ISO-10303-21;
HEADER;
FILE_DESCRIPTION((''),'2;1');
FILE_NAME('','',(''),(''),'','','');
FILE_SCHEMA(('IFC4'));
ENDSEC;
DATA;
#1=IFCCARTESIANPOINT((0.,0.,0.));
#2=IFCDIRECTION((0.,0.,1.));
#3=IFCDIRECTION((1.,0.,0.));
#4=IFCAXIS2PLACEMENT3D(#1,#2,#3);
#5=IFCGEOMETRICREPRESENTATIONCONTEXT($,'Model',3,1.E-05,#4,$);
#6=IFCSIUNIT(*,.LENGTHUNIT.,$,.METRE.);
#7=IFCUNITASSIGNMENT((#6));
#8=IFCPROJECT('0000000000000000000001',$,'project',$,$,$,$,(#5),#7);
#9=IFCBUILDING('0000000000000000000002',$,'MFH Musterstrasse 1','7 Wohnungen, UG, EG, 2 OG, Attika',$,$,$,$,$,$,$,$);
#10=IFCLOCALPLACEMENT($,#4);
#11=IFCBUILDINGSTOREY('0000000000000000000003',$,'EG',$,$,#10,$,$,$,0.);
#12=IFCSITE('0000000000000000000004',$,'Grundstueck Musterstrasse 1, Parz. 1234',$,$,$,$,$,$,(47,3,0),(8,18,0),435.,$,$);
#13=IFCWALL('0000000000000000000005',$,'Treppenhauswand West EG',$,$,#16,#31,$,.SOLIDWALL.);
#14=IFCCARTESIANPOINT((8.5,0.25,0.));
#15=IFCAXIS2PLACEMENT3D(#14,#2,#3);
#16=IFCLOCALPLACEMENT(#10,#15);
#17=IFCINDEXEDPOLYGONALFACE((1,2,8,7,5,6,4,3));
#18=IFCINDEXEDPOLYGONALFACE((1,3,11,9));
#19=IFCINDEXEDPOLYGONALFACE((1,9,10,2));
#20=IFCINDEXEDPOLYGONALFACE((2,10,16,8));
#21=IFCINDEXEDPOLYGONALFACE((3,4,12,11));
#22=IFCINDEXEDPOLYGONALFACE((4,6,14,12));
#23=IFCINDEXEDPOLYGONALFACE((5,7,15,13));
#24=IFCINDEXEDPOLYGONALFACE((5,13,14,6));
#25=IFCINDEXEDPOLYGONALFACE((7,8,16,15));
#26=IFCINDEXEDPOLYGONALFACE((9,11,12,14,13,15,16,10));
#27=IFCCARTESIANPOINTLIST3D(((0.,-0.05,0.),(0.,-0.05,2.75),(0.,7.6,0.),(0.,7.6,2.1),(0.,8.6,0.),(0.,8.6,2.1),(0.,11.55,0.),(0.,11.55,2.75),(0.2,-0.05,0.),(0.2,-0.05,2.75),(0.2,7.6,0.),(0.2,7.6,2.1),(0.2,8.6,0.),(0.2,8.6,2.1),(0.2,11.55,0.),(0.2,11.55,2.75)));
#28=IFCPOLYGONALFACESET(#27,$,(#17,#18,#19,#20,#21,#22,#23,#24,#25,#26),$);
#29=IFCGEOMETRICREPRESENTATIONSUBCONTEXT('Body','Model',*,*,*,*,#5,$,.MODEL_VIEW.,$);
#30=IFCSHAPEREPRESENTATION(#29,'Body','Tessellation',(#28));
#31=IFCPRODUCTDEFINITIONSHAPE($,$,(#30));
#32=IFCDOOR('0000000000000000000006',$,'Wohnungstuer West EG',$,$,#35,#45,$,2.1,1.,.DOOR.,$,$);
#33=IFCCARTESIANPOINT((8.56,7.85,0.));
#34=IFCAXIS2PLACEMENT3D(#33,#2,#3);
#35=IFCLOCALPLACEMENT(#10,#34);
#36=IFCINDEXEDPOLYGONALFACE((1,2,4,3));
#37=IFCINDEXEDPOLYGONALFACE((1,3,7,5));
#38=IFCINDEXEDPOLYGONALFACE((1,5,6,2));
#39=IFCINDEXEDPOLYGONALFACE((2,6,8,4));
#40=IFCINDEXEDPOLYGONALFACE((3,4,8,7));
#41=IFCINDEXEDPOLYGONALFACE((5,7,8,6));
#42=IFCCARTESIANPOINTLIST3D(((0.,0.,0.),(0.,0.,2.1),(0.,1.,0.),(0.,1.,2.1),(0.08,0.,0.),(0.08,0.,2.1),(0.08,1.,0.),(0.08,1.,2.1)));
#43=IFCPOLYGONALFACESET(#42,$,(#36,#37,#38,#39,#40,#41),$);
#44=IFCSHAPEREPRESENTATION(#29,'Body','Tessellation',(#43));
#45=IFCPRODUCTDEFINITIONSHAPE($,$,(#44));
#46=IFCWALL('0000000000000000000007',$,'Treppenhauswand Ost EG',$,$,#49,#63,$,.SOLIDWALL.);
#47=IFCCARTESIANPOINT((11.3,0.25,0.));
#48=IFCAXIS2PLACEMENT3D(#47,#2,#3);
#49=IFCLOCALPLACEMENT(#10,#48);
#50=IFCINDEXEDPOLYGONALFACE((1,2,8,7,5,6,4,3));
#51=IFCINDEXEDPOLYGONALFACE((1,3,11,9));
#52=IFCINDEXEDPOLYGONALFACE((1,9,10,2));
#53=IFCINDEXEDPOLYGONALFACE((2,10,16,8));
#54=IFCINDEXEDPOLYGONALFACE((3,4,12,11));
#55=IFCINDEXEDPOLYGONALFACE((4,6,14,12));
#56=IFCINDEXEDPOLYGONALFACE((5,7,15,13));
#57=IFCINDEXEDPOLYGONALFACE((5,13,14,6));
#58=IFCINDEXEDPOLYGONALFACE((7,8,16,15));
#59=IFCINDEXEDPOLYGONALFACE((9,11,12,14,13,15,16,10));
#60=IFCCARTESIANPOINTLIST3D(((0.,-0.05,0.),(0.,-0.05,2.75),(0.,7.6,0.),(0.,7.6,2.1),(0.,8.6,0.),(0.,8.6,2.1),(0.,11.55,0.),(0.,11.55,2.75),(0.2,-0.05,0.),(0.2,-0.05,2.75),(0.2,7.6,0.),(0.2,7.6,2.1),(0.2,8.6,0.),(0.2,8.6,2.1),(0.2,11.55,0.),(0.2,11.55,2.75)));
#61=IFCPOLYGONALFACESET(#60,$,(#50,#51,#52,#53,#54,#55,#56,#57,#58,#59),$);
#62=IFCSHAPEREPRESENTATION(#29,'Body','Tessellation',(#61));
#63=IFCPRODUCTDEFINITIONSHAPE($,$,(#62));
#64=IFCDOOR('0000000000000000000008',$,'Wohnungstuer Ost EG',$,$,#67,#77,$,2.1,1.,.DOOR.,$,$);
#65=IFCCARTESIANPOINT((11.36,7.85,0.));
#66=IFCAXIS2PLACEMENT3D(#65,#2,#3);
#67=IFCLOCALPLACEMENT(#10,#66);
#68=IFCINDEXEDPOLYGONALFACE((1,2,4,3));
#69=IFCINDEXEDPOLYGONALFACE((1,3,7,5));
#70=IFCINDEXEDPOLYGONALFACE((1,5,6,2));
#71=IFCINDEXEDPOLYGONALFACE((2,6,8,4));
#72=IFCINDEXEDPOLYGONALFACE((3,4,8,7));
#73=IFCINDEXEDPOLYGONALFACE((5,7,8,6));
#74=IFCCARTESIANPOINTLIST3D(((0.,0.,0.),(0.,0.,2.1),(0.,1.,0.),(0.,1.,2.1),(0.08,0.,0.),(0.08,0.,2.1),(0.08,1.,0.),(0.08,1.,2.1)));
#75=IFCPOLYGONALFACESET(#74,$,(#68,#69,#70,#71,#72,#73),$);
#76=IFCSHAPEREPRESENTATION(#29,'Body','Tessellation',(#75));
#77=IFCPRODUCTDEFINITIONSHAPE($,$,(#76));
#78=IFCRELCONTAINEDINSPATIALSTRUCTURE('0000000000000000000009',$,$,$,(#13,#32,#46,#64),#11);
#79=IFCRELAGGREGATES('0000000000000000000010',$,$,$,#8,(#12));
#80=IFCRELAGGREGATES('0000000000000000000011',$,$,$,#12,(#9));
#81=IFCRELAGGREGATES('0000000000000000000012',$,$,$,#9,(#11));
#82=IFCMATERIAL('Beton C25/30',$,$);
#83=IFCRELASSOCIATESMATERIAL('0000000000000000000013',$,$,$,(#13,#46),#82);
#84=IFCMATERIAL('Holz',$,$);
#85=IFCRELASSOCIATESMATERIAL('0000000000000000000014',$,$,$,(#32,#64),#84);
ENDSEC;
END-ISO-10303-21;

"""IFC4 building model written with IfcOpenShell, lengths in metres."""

from ifc_helpers import new_model, si_unit, frame, frame_2d, origin_with_axes, place, context, subcontext, project, spatial, rectangle, extrude, material, element, fill, save


model = new_model("IFC4")

# Units and contexts
model_context = context("Model", 3, precision=1e-05, world=origin_with_axes())
body_context = subcontext(model_context, "Body", "Model", "MODEL_VIEW")
ifc_project = project(units=[si_unit("LENGTHUNIT", "METRE")], contexts=[model_context])

# Site, building, storey
site = spatial("IfcSite", under=ifc_project, Name="Grundstueck Musterstrasse 1, Parz. 1234", RefLatitude=(47, 3, 0), RefLongitude=(8, 18, 0), RefElevation=435.0)
building = spatial("IfcBuilding", under=site, Name="MFH Musterstrasse 1", Description="7 Wohnungen, UG, EG, 2 OG, Attika")
storey_placement = place(None, origin_with_axes())
storey = spatial("IfcBuildingStorey", under=building, at=storey_placement, Name="EG", Elevation=0.0)

# Walls, openings, doors
ifc_material_1 = material(Name="Beton C25/30")
wall_1_placement = place(storey_placement, frame((8.5, 0.25, 0.0), z_axis=(0.0, 0.0, 1.0), x_axis=(1.0, 0.0, 0.0)))
wall_1 = element("IfcWall", 1, at=wall_1_placement, inside=storey, material=ifc_material_1, Name="Treppenhauswand West EG", PredefinedType="SOLIDWALL", context=body_context, shape_type="SweptSolid", body=[
    extrude(rectangle(XDim=0.2, YDim=11.6, at=frame_2d((0.1, 5.75))), origin_with_axes(), (0.0, 0.0, 1.0), 2.75),
])
opening_1_placement = place(wall_1_placement, frame((-0.01, 7.6, 0.0), z_axis=(0.0, 0.0, 1.0), x_axis=(1.0, 0.0, 0.0)))
opening_1 = element("IfcOpeningElement", 2, at=opening_1_placement, cuts=wall_1, context=body_context, shape_type="SweptSolid", body=[
    extrude(rectangle(XDim=0.22, YDim=1.0, at=frame_2d((0.11, 0.5))), origin_with_axes(), (0.0, 0.0, 1.0), 2.1),
])
ifc_material_2 = material(Name="Holz")
door_1_placement = place(storey_placement, frame((8.56, 7.85, 0.0), z_axis=(0.0, 0.0, 1.0), x_axis=(1.0, 0.0, 0.0)))
door_1 = element("IfcDoor", 3, at=door_1_placement, inside=storey, material=ifc_material_2, Name="Wohnungstuer West EG", OverallHeight=2.1, OverallWidth=1.0, PredefinedType="DOOR", context=body_context, shape_type="SweptSolid", body=[
    extrude(rectangle(XDim=0.08, YDim=1.0, at=frame_2d((0.04, 0.5))), origin_with_axes(), (0.0, 0.0, 1.0), 2.1),
])
fill(opening_1, door_1)
wall_2_placement = place(storey_placement, frame((11.3, 0.25, 0.0), z_axis=(0.0, 0.0, 1.0), x_axis=(1.0, 0.0, 0.0)))
wall_2 = element("IfcWall", 4, at=wall_2_placement, inside=storey, material=ifc_material_1, Name="Treppenhauswand Ost EG", PredefinedType="SOLIDWALL", context=body_context, shape_type="SweptSolid", body=[
    extrude(rectangle(XDim=0.2, YDim=11.6, at=frame_2d((0.1, 5.75))), origin_with_axes(), (0.0, 0.0, 1.0), 2.75),
])
opening_2_placement = place(wall_2_placement, frame((-0.01, 7.6, 0.0), z_axis=(0.0, 0.0, 1.0), x_axis=(1.0, 0.0, 0.0)))
opening_2 = element("IfcOpeningElement", 5, at=opening_2_placement, cuts=wall_2, context=body_context, shape_type="SweptSolid", body=[
    extrude(rectangle(XDim=0.22, YDim=1.0, at=frame_2d((0.11, 0.5))), origin_with_axes(), (0.0, 0.0, 1.0), 2.1),
])
door_2_placement = place(storey_placement, frame((11.36, 7.85, 0.0), z_axis=(0.0, 0.0, 1.0), x_axis=(1.0, 0.0, 0.0)))
door_2 = element("IfcDoor", 6, at=door_2_placement, inside=storey, material=ifc_material_2, Name="Wohnungstuer Ost EG", OverallHeight=2.1, OverallWidth=1.0, PredefinedType="DOOR", context=body_context, shape_type="SweptSolid", body=[
    extrude(rectangle(XDim=0.08, YDim=1.0, at=frame_2d((0.04, 0.5))), origin_with_axes(), (0.0, 0.0, 1.0), 2.1),
])
fill(opening_2, door_2)

save(model, "model.ifc")
